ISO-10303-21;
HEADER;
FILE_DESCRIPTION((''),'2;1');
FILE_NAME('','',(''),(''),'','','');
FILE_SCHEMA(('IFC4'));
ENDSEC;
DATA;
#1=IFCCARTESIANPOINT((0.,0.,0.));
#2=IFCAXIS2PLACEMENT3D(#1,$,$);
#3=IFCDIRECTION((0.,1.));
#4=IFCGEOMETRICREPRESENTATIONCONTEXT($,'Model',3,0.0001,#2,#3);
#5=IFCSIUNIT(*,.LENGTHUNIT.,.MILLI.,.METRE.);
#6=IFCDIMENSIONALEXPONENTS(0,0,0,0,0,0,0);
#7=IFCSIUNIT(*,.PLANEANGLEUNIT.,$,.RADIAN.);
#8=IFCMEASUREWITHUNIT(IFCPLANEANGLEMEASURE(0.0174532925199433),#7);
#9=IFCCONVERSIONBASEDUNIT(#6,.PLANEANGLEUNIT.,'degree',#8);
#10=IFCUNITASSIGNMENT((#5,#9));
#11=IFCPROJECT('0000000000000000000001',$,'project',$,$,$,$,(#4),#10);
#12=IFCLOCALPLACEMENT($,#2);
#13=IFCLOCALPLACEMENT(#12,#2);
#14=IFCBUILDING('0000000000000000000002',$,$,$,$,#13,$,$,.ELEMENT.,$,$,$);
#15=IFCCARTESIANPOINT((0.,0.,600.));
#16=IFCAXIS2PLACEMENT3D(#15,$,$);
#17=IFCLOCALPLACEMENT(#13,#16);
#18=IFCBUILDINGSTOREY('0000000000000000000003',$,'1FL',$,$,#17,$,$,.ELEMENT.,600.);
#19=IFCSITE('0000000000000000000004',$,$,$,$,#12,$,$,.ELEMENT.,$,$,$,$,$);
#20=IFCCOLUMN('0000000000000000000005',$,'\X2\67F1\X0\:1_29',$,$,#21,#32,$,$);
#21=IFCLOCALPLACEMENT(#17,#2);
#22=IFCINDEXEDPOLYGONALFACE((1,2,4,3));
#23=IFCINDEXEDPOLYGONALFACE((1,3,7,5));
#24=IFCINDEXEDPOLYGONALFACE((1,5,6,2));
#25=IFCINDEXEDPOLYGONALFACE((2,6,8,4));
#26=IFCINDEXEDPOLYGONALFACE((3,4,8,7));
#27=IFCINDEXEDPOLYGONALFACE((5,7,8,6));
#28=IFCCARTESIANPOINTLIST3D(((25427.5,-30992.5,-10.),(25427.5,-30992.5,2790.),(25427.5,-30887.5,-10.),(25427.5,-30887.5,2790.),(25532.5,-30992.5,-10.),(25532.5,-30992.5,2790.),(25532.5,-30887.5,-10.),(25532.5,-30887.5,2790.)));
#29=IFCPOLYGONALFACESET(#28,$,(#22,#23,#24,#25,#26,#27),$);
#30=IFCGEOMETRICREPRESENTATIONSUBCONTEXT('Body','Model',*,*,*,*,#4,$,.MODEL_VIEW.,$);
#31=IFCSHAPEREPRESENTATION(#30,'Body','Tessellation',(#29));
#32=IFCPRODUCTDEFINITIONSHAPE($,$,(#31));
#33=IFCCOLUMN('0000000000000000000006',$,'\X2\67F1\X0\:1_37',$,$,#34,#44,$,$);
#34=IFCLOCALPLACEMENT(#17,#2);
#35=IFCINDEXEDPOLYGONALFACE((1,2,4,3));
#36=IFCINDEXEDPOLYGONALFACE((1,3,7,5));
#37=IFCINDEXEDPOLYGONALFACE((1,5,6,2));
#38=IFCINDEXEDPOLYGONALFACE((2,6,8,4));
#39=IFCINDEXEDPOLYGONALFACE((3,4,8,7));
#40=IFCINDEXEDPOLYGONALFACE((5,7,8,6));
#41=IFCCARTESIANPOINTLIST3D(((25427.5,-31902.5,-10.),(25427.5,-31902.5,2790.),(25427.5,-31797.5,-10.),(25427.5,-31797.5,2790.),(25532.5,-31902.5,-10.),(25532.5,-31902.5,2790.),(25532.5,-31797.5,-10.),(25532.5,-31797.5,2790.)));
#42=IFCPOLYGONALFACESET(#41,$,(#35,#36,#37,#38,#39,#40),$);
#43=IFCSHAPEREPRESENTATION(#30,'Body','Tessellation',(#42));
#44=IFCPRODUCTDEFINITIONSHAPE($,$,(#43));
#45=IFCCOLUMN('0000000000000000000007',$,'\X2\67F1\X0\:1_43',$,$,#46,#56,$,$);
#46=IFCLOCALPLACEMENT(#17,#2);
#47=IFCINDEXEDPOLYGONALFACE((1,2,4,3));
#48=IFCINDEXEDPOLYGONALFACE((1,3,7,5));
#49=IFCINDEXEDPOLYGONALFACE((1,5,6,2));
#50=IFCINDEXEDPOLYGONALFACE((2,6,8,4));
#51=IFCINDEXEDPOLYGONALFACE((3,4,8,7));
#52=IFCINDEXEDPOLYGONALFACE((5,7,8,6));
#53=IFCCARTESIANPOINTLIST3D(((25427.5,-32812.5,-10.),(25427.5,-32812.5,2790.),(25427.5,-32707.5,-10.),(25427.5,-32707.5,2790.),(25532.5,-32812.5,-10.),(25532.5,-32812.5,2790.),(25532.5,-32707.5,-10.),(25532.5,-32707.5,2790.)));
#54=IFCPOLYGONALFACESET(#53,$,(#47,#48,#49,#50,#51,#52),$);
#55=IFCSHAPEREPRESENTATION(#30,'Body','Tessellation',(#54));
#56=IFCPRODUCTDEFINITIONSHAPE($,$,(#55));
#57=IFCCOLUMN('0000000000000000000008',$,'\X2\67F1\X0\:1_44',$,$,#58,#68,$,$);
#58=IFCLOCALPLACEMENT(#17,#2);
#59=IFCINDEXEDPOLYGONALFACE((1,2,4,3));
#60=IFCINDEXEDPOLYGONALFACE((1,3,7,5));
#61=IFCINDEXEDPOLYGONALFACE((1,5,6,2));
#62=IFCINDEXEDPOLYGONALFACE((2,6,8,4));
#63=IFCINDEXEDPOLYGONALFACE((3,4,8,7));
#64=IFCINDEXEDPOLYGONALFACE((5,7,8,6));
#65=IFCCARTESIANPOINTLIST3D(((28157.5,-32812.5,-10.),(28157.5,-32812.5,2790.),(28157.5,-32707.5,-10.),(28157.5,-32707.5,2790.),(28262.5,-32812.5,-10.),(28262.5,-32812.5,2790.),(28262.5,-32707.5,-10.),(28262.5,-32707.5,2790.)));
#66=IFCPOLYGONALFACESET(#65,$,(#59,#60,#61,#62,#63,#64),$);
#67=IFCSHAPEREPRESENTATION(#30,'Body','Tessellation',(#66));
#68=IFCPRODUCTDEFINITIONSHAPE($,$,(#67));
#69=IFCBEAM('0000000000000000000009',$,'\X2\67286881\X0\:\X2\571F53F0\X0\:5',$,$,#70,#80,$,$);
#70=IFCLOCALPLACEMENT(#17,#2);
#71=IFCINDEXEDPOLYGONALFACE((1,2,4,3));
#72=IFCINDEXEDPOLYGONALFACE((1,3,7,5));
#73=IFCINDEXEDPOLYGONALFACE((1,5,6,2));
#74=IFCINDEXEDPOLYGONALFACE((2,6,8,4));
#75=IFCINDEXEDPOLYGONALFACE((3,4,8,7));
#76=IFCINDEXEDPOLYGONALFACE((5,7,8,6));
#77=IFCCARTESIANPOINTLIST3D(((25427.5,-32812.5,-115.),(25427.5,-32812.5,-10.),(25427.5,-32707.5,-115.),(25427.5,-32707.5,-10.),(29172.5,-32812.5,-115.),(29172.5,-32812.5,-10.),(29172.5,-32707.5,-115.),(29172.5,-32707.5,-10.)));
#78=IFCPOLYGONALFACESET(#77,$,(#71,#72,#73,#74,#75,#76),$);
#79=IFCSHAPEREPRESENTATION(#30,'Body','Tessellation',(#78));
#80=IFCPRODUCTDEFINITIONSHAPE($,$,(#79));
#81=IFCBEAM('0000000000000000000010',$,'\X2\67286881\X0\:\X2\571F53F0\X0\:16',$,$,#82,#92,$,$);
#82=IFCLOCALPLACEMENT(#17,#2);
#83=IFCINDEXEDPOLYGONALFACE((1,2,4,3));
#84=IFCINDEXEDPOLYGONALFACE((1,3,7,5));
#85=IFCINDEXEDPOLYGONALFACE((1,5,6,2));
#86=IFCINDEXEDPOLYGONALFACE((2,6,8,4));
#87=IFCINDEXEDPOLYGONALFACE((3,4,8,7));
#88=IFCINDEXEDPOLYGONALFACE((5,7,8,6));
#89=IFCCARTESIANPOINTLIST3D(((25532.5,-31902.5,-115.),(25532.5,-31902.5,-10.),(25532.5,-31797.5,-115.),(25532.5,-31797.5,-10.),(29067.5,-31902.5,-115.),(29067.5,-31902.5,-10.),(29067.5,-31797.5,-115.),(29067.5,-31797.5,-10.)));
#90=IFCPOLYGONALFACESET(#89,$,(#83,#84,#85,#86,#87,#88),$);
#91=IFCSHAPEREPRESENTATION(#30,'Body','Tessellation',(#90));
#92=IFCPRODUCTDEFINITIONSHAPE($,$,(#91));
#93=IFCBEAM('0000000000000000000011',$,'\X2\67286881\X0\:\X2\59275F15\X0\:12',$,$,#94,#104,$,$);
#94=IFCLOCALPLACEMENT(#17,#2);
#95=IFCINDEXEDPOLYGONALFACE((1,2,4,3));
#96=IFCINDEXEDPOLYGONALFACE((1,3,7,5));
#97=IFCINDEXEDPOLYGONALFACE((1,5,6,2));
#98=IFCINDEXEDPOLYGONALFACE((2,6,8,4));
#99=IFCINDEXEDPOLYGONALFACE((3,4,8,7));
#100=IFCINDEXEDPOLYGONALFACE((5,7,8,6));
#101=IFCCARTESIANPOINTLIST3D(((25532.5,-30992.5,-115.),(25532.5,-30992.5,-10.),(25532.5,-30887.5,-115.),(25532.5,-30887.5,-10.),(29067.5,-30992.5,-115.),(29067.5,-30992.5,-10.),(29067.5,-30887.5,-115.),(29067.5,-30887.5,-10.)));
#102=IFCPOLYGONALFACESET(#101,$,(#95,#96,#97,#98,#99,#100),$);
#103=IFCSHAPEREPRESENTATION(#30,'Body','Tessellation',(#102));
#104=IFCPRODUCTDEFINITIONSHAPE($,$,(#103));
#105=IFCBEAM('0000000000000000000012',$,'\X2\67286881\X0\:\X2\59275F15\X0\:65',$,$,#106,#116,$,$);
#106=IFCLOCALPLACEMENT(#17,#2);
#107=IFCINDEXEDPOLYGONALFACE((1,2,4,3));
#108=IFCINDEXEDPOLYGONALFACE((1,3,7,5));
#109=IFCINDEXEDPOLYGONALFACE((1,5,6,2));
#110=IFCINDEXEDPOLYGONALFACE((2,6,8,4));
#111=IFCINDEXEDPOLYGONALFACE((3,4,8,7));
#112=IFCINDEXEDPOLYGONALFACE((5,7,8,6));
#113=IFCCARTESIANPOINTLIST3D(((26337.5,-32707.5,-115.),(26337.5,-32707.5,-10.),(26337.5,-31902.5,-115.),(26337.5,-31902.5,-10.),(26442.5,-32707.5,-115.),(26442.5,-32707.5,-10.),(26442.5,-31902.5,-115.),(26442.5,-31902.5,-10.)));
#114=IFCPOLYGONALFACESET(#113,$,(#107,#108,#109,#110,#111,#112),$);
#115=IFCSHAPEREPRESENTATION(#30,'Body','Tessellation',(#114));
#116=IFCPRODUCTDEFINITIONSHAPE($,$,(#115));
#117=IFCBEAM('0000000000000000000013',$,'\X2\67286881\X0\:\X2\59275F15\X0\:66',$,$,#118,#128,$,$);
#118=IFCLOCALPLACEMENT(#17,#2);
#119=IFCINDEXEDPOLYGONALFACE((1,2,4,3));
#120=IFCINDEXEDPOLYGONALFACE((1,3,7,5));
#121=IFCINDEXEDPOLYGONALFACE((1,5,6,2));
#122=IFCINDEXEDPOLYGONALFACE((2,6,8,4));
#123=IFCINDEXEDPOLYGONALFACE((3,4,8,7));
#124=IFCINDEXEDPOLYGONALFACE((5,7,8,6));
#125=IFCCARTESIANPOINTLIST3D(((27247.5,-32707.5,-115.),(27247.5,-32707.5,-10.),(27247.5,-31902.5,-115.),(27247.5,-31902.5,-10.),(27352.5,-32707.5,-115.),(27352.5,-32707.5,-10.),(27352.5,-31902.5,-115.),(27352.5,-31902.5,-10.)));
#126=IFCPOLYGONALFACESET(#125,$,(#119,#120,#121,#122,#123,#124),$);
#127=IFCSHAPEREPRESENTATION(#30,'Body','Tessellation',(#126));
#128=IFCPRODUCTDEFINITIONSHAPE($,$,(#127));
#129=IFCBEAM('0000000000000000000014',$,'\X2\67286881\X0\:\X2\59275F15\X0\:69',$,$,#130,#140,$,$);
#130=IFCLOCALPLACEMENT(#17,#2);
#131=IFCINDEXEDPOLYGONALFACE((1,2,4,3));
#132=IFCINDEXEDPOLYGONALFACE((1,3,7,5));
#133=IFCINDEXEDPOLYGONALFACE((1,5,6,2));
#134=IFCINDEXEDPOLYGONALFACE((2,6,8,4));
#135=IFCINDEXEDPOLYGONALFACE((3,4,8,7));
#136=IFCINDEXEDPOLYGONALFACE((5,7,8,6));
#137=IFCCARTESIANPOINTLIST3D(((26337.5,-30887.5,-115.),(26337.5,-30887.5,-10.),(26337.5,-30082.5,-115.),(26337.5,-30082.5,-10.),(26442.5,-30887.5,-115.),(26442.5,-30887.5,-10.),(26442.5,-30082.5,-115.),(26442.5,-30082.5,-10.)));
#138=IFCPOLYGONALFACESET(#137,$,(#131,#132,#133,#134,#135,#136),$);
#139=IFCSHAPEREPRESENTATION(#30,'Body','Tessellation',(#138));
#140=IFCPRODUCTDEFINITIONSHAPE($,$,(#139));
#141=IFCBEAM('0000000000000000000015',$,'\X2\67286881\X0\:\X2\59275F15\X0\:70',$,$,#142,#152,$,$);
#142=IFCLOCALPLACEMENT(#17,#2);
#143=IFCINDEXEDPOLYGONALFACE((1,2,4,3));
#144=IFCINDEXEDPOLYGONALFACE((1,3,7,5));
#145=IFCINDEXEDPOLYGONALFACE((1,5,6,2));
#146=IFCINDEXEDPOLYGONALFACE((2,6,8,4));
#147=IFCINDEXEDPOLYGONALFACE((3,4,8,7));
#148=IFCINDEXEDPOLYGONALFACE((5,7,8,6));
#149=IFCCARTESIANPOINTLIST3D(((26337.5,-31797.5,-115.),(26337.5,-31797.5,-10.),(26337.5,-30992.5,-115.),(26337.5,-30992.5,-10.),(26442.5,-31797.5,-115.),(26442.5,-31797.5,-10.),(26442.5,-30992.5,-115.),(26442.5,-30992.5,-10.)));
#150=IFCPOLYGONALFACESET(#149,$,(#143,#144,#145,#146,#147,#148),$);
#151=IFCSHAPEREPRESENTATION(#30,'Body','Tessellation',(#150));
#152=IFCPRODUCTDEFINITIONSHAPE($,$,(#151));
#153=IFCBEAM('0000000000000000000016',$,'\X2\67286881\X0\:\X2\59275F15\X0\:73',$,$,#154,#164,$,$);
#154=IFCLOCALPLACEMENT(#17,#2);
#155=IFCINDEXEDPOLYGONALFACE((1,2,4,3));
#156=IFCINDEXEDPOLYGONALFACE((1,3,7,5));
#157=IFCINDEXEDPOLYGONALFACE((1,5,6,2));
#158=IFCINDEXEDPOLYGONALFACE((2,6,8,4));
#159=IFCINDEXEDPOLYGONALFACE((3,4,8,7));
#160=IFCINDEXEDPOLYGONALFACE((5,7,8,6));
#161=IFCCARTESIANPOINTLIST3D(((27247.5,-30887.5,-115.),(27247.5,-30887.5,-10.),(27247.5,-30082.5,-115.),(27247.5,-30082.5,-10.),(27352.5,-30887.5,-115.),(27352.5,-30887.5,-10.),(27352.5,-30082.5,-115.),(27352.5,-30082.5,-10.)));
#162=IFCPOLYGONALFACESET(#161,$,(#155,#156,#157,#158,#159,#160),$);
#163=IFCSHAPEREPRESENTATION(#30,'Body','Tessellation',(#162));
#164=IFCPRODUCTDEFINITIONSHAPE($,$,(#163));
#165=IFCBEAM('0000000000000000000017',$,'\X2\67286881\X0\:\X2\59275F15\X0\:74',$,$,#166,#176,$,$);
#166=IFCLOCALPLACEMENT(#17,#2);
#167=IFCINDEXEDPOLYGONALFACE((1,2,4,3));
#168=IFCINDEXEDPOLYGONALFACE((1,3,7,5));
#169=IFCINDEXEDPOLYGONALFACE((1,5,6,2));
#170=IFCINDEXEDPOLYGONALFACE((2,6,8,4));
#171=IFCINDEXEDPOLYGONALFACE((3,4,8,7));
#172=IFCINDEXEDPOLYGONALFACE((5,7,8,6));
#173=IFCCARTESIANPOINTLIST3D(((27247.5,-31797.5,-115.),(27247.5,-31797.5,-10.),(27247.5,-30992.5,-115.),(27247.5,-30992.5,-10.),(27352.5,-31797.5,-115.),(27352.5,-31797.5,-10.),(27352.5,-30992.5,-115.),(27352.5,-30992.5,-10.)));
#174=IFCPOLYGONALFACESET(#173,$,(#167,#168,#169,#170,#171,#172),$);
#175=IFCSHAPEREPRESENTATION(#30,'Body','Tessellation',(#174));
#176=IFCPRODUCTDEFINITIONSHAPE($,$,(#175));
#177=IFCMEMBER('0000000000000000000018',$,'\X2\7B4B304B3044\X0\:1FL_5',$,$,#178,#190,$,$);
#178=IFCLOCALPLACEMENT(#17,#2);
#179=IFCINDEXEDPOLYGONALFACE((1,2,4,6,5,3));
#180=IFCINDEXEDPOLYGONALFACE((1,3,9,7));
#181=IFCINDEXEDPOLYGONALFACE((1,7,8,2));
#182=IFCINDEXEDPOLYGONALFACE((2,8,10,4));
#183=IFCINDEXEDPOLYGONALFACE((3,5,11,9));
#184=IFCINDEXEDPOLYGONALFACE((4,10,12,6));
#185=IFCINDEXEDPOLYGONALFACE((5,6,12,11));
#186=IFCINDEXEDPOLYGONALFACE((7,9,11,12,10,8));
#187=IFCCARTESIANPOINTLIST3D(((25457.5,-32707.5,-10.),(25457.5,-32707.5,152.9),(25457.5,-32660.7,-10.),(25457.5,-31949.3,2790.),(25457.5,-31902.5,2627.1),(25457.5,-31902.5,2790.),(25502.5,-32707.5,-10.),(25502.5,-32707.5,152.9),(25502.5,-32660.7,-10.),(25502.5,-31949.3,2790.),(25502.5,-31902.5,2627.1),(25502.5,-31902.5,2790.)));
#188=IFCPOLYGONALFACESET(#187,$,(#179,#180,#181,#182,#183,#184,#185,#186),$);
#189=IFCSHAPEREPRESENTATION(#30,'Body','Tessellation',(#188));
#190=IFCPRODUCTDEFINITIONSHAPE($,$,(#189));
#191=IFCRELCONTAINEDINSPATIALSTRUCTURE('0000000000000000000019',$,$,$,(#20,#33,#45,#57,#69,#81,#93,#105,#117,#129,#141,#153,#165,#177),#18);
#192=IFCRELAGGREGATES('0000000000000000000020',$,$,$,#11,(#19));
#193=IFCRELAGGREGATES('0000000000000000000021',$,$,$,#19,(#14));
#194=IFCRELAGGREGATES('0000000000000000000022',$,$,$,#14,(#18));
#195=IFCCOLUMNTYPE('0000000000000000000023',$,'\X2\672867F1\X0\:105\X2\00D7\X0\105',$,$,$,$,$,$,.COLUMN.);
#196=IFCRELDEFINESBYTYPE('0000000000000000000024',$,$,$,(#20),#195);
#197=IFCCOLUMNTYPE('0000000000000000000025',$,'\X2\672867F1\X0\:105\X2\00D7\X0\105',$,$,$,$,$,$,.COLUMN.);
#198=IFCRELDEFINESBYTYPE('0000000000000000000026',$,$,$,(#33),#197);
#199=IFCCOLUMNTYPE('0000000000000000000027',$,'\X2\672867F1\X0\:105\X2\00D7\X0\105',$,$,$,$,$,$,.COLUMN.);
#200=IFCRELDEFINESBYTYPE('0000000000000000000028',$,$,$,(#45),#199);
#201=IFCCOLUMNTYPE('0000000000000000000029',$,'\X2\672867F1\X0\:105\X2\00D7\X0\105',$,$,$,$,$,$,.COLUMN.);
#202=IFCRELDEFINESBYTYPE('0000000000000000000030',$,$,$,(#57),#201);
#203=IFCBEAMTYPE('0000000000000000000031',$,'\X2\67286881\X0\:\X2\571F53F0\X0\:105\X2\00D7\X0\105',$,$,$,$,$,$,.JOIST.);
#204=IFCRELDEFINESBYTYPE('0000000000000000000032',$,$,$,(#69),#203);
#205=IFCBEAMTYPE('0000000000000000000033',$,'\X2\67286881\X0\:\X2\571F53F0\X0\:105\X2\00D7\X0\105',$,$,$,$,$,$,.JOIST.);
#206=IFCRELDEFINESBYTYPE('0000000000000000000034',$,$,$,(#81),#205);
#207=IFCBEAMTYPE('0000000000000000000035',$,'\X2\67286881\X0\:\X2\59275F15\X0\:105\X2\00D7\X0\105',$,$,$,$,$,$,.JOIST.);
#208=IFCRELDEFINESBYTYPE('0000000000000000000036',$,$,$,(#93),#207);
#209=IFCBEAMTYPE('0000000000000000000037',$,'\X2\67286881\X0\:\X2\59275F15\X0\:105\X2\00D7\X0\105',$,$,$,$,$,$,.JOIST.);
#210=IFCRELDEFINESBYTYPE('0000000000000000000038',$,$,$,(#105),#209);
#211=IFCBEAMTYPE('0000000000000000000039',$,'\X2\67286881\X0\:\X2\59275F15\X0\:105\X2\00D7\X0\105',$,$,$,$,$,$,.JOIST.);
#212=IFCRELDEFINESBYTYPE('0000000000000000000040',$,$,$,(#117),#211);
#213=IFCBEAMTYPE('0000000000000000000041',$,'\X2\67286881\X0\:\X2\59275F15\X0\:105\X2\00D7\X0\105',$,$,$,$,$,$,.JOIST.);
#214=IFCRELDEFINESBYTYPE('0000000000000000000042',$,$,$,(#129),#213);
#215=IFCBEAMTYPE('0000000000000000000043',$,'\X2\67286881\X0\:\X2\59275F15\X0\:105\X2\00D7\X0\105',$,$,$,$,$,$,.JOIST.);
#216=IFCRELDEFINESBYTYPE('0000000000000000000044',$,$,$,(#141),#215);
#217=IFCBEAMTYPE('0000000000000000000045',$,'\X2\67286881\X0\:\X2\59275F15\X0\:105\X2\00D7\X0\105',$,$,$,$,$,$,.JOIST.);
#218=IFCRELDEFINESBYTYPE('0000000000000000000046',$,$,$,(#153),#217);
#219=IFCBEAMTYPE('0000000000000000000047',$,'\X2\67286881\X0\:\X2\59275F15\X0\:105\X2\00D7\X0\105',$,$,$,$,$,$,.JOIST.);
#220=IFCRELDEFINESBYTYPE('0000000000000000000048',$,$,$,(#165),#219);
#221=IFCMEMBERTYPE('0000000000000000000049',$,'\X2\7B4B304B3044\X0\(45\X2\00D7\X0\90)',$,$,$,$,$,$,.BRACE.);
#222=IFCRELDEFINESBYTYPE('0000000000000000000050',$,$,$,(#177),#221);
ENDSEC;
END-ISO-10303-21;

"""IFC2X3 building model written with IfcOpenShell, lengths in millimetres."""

from ifc_helpers import new_model, entity, si_unit, converted_unit, direction, frame, origin, origin_with_axes, origin_2d, place, context, subcontext, project, spatial, polyline, rectangle, outline, extrude, type_object, element, save


model = new_model("IFC2X3")

# Units and contexts
model_context = context("Model", 3, precision=0.0001, world=origin(), true_north=direction((0.0, 1.0)))
body_context = subcontext(model_context, "Body", "Model", "MODEL_VIEW")
ifc_project = project(units=[si_unit("LENGTHUNIT", "METRE", prefix="MILLI"), converted_unit("PLANEANGLEUNIT", "degree", entity("IfcPlaneAngleMeasure", 0.0174532925199433), si_unit("PLANEANGLEUNIT", "RADIAN"), dimensions=[0, 0, 0, 0, 0, 0, 0])], contexts=[model_context])

# Site, building, storey
site_placement = place(None, origin())
site = spatial("IfcSite", under=ifc_project, at=site_placement, CompositionType="ELEMENT")
building_placement = place(site_placement, origin())
building = spatial("IfcBuilding", under=site, at=building_placement, CompositionType="ELEMENT")
storey_placement = place(building_placement, frame((0.0, 0.0, 600.0)))
storey = spatial("IfcBuildingStorey", under=building, at=storey_placement, Name="1FL", CompositionType="ELEMENT", Elevation=600.0)

# Columns
column_type_1 = type_object("IfcColumnType", Name="木柱:105×105", PredefinedType="COLUMN")
column_1_placement = place(storey_placement, frame((25480.0, -30940.0, -10.0)))
element("IfcColumn", 1, at=column_1_placement, inside=storey, type_object=column_type_1, Name="柱:1_29", context=body_context, shape_type="SweptSolid", body=[
    extrude(rectangle(XDim=105.0, YDim=105.0, at=origin_2d()), origin_with_axes(), (0.0, 0.0, 1.0), 2800.0),
])
column_type_2 = type_object("IfcColumnType", Name="木柱:105×105", PredefinedType="COLUMN")
column_2_placement = place(storey_placement, frame((25480.0, -31850.0, -10.0)))
element("IfcColumn", 2, at=column_2_placement, inside=storey, type_object=column_type_2, Name="柱:1_37", context=body_context, shape_type="SweptSolid", body=[
    extrude(rectangle(XDim=105.0, YDim=105.0, at=origin_2d()), origin_with_axes(), (0.0, 0.0, 1.0), 2800.0),
])
column_type_3 = type_object("IfcColumnType", Name="木柱:105×105", PredefinedType="COLUMN")
column_3_placement = place(storey_placement, frame((25480.0, -32760.0, -10.0)))
element("IfcColumn", 3, at=column_3_placement, inside=storey, type_object=column_type_3, Name="柱:1_43", context=body_context, shape_type="SweptSolid", body=[
    extrude(rectangle(XDim=105.0, YDim=105.0, at=origin_2d()), origin_with_axes(), (0.0, 0.0, 1.0), 2800.0),
])
column_type_4 = type_object("IfcColumnType", Name="木柱:105×105", PredefinedType="COLUMN")
column_4_placement = place(storey_placement, frame((28210.0, -32760.0, -10.0)))
element("IfcColumn", 4, at=column_4_placement, inside=storey, type_object=column_type_4, Name="柱:1_44", context=body_context, shape_type="SweptSolid", body=[
    extrude(rectangle(XDim=105.0, YDim=105.0, at=origin_2d()), origin_with_axes(), (0.0, 0.0, 1.0), 2800.0),
])

# Beams
beam_type_1 = type_object("IfcBeamType", Name="木梁:土台:105×105", PredefinedType="JOIST")
beam_1_placement = place(storey_placement, frame((25427.5, -32760.0, -62.5), z_axis=(1.0, 0.0, 0.0), x_axis=(0.0, 1.0, 0.0)))
element("IfcBeam", 5, at=beam_1_placement, inside=storey, type_object=beam_type_1, Name="木梁:土台:5", context=body_context, shape_type="SweptSolid", body=[
    extrude(rectangle(XDim=105.0, YDim=105.0, at=origin_2d()), origin_with_axes(), (0.0, 0.0, 1.0), 3745.0),
])
beam_type_2 = type_object("IfcBeamType", Name="木梁:土台:105×105", PredefinedType="JOIST")
beam_2_placement = place(storey_placement, frame((25532.5, -31850.0, -62.5), z_axis=(1.0, 0.0, 0.0), x_axis=(0.0, 1.0, 0.0)))
element("IfcBeam", 6, at=beam_2_placement, inside=storey, type_object=beam_type_2, Name="木梁:土台:16", context=body_context, shape_type="SweptSolid", body=[
    extrude(rectangle(XDim=105.0, YDim=105.0, at=origin_2d()), origin_with_axes(), (0.0, 0.0, 1.0), 3535.0),
])
beam_type_3 = type_object("IfcBeamType", Name="木梁:大引:105×105", PredefinedType="JOIST")
beam_3_placement = place(storey_placement, frame((25532.5, -30940.0, -62.5), z_axis=(1.0, 0.0, 0.0), x_axis=(0.0, 1.0, 0.0)))
element("IfcBeam", 7, at=beam_3_placement, inside=storey, type_object=beam_type_3, Name="木梁:大引:12", context=body_context, shape_type="SweptSolid", body=[
    extrude(rectangle(XDim=105.0, YDim=105.0, at=origin_2d()), origin_with_axes(), (0.0, 0.0, 1.0), 3535.0),
])
beam_type_4 = type_object("IfcBeamType", Name="木梁:大引:105×105", PredefinedType="JOIST")
beam_4_placement = place(storey_placement, frame((26390.0, -31902.5, -62.5), z_axis=(0.0, -1.0, 0.0), x_axis=(1.0, 0.0, 0.0)))
element("IfcBeam", 8, at=beam_4_placement, inside=storey, type_object=beam_type_4, Name="木梁:大引:65", context=body_context, shape_type="SweptSolid", body=[
    extrude(rectangle(XDim=105.0, YDim=105.0, at=origin_2d()), origin_with_axes(), (0.0, 0.0, 1.0), 805.0),
])
beam_type_5 = type_object("IfcBeamType", Name="木梁:大引:105×105", PredefinedType="JOIST")
beam_5_placement = place(storey_placement, frame((27300.0, -31902.5, -62.5), z_axis=(0.0, -1.0, 0.0), x_axis=(1.0, 0.0, 0.0)))
element("IfcBeam", 9, at=beam_5_placement, inside=storey, type_object=beam_type_5, Name="木梁:大引:66", context=body_context, shape_type="SweptSolid", body=[
    extrude(rectangle(XDim=105.0, YDim=105.0, at=origin_2d()), origin_with_axes(), (0.0, 0.0, 1.0), 805.0),
])
beam_type_6 = type_object("IfcBeamType", Name="木梁:大引:105×105", PredefinedType="JOIST")
beam_6_placement = place(storey_placement, frame((26390.0, -30082.5, -62.5), z_axis=(0.0, -1.0, 0.0), x_axis=(1.0, 0.0, 0.0)))
element("IfcBeam", 10, at=beam_6_placement, inside=storey, type_object=beam_type_6, Name="木梁:大引:69", context=body_context, shape_type="SweptSolid", body=[
    extrude(rectangle(XDim=105.0, YDim=105.0, at=origin_2d()), origin_with_axes(), (0.0, 0.0, 1.0), 805.0),
])
beam_type_7 = type_object("IfcBeamType", Name="木梁:大引:105×105", PredefinedType="JOIST")
beam_7_placement = place(storey_placement, frame((26390.0, -30992.5, -62.5), z_axis=(0.0, -1.0, 0.0), x_axis=(1.0, 0.0, 0.0)))
element("IfcBeam", 11, at=beam_7_placement, inside=storey, type_object=beam_type_7, Name="木梁:大引:70", context=body_context, shape_type="SweptSolid", body=[
    extrude(rectangle(XDim=105.0, YDim=105.0, at=origin_2d()), origin_with_axes(), (0.0, 0.0, 1.0), 805.0),
])
beam_type_8 = type_object("IfcBeamType", Name="木梁:大引:105×105", PredefinedType="JOIST")
beam_8_placement = place(storey_placement, frame((27300.0, -30082.5, -62.5), z_axis=(0.0, -1.0, 0.0), x_axis=(1.0, 0.0, 0.0)))
element("IfcBeam", 12, at=beam_8_placement, inside=storey, type_object=beam_type_8, Name="木梁:大引:73", context=body_context, shape_type="SweptSolid", body=[
    extrude(rectangle(XDim=105.0, YDim=105.0, at=origin_2d()), origin_with_axes(), (0.0, 0.0, 1.0), 805.0),
])
beam_type_9 = type_object("IfcBeamType", Name="木梁:大引:105×105", PredefinedType="JOIST")
beam_9_placement = place(storey_placement, frame((27300.0, -30992.5, -62.5), z_axis=(0.0, -1.0, 0.0), x_axis=(1.0, 0.0, 0.0)))
element("IfcBeam", 13, at=beam_9_placement, inside=storey, type_object=beam_type_9, Name="木梁:大引:74", context=body_context, shape_type="SweptSolid", body=[
    extrude(rectangle(XDim=105.0, YDim=105.0, at=origin_2d()), origin_with_axes(), (0.0, 0.0, 1.0), 805.0),
])

# Member
member_type = type_object("IfcMemberType", Name="筋かい(45×90)", PredefinedType="BRACE")
member_placement = place(storey_placement, frame((25480.0, -32707.5, -10.0), z_axis=(0.0, 0.276307, 0.961069), x_axis=(0.0, -0.961069, 0.276307)))
element("IfcMember", 14, at=member_placement, inside=storey, type_object=member_type, Name="筋かい:1FL_5", context=body_context, shape_type="SweptSolid", body=[
    extrude(outline(polyline([(0.0, 0.0), (12.9, -45.0), (2756.9, -45.0), (2913.4, 0.0), (2900.5, 45.0), (156.5, 45.0), (0.0, 0.0)])), frame((0.0, -22.5, 0.0), z_axis=(0.0, 1.0, 0.0), x_axis=(0.0, 0.0, 1.0)), (0.0, 0.0, 1.0), 45.0),
])

save(model, "model.ifc")
